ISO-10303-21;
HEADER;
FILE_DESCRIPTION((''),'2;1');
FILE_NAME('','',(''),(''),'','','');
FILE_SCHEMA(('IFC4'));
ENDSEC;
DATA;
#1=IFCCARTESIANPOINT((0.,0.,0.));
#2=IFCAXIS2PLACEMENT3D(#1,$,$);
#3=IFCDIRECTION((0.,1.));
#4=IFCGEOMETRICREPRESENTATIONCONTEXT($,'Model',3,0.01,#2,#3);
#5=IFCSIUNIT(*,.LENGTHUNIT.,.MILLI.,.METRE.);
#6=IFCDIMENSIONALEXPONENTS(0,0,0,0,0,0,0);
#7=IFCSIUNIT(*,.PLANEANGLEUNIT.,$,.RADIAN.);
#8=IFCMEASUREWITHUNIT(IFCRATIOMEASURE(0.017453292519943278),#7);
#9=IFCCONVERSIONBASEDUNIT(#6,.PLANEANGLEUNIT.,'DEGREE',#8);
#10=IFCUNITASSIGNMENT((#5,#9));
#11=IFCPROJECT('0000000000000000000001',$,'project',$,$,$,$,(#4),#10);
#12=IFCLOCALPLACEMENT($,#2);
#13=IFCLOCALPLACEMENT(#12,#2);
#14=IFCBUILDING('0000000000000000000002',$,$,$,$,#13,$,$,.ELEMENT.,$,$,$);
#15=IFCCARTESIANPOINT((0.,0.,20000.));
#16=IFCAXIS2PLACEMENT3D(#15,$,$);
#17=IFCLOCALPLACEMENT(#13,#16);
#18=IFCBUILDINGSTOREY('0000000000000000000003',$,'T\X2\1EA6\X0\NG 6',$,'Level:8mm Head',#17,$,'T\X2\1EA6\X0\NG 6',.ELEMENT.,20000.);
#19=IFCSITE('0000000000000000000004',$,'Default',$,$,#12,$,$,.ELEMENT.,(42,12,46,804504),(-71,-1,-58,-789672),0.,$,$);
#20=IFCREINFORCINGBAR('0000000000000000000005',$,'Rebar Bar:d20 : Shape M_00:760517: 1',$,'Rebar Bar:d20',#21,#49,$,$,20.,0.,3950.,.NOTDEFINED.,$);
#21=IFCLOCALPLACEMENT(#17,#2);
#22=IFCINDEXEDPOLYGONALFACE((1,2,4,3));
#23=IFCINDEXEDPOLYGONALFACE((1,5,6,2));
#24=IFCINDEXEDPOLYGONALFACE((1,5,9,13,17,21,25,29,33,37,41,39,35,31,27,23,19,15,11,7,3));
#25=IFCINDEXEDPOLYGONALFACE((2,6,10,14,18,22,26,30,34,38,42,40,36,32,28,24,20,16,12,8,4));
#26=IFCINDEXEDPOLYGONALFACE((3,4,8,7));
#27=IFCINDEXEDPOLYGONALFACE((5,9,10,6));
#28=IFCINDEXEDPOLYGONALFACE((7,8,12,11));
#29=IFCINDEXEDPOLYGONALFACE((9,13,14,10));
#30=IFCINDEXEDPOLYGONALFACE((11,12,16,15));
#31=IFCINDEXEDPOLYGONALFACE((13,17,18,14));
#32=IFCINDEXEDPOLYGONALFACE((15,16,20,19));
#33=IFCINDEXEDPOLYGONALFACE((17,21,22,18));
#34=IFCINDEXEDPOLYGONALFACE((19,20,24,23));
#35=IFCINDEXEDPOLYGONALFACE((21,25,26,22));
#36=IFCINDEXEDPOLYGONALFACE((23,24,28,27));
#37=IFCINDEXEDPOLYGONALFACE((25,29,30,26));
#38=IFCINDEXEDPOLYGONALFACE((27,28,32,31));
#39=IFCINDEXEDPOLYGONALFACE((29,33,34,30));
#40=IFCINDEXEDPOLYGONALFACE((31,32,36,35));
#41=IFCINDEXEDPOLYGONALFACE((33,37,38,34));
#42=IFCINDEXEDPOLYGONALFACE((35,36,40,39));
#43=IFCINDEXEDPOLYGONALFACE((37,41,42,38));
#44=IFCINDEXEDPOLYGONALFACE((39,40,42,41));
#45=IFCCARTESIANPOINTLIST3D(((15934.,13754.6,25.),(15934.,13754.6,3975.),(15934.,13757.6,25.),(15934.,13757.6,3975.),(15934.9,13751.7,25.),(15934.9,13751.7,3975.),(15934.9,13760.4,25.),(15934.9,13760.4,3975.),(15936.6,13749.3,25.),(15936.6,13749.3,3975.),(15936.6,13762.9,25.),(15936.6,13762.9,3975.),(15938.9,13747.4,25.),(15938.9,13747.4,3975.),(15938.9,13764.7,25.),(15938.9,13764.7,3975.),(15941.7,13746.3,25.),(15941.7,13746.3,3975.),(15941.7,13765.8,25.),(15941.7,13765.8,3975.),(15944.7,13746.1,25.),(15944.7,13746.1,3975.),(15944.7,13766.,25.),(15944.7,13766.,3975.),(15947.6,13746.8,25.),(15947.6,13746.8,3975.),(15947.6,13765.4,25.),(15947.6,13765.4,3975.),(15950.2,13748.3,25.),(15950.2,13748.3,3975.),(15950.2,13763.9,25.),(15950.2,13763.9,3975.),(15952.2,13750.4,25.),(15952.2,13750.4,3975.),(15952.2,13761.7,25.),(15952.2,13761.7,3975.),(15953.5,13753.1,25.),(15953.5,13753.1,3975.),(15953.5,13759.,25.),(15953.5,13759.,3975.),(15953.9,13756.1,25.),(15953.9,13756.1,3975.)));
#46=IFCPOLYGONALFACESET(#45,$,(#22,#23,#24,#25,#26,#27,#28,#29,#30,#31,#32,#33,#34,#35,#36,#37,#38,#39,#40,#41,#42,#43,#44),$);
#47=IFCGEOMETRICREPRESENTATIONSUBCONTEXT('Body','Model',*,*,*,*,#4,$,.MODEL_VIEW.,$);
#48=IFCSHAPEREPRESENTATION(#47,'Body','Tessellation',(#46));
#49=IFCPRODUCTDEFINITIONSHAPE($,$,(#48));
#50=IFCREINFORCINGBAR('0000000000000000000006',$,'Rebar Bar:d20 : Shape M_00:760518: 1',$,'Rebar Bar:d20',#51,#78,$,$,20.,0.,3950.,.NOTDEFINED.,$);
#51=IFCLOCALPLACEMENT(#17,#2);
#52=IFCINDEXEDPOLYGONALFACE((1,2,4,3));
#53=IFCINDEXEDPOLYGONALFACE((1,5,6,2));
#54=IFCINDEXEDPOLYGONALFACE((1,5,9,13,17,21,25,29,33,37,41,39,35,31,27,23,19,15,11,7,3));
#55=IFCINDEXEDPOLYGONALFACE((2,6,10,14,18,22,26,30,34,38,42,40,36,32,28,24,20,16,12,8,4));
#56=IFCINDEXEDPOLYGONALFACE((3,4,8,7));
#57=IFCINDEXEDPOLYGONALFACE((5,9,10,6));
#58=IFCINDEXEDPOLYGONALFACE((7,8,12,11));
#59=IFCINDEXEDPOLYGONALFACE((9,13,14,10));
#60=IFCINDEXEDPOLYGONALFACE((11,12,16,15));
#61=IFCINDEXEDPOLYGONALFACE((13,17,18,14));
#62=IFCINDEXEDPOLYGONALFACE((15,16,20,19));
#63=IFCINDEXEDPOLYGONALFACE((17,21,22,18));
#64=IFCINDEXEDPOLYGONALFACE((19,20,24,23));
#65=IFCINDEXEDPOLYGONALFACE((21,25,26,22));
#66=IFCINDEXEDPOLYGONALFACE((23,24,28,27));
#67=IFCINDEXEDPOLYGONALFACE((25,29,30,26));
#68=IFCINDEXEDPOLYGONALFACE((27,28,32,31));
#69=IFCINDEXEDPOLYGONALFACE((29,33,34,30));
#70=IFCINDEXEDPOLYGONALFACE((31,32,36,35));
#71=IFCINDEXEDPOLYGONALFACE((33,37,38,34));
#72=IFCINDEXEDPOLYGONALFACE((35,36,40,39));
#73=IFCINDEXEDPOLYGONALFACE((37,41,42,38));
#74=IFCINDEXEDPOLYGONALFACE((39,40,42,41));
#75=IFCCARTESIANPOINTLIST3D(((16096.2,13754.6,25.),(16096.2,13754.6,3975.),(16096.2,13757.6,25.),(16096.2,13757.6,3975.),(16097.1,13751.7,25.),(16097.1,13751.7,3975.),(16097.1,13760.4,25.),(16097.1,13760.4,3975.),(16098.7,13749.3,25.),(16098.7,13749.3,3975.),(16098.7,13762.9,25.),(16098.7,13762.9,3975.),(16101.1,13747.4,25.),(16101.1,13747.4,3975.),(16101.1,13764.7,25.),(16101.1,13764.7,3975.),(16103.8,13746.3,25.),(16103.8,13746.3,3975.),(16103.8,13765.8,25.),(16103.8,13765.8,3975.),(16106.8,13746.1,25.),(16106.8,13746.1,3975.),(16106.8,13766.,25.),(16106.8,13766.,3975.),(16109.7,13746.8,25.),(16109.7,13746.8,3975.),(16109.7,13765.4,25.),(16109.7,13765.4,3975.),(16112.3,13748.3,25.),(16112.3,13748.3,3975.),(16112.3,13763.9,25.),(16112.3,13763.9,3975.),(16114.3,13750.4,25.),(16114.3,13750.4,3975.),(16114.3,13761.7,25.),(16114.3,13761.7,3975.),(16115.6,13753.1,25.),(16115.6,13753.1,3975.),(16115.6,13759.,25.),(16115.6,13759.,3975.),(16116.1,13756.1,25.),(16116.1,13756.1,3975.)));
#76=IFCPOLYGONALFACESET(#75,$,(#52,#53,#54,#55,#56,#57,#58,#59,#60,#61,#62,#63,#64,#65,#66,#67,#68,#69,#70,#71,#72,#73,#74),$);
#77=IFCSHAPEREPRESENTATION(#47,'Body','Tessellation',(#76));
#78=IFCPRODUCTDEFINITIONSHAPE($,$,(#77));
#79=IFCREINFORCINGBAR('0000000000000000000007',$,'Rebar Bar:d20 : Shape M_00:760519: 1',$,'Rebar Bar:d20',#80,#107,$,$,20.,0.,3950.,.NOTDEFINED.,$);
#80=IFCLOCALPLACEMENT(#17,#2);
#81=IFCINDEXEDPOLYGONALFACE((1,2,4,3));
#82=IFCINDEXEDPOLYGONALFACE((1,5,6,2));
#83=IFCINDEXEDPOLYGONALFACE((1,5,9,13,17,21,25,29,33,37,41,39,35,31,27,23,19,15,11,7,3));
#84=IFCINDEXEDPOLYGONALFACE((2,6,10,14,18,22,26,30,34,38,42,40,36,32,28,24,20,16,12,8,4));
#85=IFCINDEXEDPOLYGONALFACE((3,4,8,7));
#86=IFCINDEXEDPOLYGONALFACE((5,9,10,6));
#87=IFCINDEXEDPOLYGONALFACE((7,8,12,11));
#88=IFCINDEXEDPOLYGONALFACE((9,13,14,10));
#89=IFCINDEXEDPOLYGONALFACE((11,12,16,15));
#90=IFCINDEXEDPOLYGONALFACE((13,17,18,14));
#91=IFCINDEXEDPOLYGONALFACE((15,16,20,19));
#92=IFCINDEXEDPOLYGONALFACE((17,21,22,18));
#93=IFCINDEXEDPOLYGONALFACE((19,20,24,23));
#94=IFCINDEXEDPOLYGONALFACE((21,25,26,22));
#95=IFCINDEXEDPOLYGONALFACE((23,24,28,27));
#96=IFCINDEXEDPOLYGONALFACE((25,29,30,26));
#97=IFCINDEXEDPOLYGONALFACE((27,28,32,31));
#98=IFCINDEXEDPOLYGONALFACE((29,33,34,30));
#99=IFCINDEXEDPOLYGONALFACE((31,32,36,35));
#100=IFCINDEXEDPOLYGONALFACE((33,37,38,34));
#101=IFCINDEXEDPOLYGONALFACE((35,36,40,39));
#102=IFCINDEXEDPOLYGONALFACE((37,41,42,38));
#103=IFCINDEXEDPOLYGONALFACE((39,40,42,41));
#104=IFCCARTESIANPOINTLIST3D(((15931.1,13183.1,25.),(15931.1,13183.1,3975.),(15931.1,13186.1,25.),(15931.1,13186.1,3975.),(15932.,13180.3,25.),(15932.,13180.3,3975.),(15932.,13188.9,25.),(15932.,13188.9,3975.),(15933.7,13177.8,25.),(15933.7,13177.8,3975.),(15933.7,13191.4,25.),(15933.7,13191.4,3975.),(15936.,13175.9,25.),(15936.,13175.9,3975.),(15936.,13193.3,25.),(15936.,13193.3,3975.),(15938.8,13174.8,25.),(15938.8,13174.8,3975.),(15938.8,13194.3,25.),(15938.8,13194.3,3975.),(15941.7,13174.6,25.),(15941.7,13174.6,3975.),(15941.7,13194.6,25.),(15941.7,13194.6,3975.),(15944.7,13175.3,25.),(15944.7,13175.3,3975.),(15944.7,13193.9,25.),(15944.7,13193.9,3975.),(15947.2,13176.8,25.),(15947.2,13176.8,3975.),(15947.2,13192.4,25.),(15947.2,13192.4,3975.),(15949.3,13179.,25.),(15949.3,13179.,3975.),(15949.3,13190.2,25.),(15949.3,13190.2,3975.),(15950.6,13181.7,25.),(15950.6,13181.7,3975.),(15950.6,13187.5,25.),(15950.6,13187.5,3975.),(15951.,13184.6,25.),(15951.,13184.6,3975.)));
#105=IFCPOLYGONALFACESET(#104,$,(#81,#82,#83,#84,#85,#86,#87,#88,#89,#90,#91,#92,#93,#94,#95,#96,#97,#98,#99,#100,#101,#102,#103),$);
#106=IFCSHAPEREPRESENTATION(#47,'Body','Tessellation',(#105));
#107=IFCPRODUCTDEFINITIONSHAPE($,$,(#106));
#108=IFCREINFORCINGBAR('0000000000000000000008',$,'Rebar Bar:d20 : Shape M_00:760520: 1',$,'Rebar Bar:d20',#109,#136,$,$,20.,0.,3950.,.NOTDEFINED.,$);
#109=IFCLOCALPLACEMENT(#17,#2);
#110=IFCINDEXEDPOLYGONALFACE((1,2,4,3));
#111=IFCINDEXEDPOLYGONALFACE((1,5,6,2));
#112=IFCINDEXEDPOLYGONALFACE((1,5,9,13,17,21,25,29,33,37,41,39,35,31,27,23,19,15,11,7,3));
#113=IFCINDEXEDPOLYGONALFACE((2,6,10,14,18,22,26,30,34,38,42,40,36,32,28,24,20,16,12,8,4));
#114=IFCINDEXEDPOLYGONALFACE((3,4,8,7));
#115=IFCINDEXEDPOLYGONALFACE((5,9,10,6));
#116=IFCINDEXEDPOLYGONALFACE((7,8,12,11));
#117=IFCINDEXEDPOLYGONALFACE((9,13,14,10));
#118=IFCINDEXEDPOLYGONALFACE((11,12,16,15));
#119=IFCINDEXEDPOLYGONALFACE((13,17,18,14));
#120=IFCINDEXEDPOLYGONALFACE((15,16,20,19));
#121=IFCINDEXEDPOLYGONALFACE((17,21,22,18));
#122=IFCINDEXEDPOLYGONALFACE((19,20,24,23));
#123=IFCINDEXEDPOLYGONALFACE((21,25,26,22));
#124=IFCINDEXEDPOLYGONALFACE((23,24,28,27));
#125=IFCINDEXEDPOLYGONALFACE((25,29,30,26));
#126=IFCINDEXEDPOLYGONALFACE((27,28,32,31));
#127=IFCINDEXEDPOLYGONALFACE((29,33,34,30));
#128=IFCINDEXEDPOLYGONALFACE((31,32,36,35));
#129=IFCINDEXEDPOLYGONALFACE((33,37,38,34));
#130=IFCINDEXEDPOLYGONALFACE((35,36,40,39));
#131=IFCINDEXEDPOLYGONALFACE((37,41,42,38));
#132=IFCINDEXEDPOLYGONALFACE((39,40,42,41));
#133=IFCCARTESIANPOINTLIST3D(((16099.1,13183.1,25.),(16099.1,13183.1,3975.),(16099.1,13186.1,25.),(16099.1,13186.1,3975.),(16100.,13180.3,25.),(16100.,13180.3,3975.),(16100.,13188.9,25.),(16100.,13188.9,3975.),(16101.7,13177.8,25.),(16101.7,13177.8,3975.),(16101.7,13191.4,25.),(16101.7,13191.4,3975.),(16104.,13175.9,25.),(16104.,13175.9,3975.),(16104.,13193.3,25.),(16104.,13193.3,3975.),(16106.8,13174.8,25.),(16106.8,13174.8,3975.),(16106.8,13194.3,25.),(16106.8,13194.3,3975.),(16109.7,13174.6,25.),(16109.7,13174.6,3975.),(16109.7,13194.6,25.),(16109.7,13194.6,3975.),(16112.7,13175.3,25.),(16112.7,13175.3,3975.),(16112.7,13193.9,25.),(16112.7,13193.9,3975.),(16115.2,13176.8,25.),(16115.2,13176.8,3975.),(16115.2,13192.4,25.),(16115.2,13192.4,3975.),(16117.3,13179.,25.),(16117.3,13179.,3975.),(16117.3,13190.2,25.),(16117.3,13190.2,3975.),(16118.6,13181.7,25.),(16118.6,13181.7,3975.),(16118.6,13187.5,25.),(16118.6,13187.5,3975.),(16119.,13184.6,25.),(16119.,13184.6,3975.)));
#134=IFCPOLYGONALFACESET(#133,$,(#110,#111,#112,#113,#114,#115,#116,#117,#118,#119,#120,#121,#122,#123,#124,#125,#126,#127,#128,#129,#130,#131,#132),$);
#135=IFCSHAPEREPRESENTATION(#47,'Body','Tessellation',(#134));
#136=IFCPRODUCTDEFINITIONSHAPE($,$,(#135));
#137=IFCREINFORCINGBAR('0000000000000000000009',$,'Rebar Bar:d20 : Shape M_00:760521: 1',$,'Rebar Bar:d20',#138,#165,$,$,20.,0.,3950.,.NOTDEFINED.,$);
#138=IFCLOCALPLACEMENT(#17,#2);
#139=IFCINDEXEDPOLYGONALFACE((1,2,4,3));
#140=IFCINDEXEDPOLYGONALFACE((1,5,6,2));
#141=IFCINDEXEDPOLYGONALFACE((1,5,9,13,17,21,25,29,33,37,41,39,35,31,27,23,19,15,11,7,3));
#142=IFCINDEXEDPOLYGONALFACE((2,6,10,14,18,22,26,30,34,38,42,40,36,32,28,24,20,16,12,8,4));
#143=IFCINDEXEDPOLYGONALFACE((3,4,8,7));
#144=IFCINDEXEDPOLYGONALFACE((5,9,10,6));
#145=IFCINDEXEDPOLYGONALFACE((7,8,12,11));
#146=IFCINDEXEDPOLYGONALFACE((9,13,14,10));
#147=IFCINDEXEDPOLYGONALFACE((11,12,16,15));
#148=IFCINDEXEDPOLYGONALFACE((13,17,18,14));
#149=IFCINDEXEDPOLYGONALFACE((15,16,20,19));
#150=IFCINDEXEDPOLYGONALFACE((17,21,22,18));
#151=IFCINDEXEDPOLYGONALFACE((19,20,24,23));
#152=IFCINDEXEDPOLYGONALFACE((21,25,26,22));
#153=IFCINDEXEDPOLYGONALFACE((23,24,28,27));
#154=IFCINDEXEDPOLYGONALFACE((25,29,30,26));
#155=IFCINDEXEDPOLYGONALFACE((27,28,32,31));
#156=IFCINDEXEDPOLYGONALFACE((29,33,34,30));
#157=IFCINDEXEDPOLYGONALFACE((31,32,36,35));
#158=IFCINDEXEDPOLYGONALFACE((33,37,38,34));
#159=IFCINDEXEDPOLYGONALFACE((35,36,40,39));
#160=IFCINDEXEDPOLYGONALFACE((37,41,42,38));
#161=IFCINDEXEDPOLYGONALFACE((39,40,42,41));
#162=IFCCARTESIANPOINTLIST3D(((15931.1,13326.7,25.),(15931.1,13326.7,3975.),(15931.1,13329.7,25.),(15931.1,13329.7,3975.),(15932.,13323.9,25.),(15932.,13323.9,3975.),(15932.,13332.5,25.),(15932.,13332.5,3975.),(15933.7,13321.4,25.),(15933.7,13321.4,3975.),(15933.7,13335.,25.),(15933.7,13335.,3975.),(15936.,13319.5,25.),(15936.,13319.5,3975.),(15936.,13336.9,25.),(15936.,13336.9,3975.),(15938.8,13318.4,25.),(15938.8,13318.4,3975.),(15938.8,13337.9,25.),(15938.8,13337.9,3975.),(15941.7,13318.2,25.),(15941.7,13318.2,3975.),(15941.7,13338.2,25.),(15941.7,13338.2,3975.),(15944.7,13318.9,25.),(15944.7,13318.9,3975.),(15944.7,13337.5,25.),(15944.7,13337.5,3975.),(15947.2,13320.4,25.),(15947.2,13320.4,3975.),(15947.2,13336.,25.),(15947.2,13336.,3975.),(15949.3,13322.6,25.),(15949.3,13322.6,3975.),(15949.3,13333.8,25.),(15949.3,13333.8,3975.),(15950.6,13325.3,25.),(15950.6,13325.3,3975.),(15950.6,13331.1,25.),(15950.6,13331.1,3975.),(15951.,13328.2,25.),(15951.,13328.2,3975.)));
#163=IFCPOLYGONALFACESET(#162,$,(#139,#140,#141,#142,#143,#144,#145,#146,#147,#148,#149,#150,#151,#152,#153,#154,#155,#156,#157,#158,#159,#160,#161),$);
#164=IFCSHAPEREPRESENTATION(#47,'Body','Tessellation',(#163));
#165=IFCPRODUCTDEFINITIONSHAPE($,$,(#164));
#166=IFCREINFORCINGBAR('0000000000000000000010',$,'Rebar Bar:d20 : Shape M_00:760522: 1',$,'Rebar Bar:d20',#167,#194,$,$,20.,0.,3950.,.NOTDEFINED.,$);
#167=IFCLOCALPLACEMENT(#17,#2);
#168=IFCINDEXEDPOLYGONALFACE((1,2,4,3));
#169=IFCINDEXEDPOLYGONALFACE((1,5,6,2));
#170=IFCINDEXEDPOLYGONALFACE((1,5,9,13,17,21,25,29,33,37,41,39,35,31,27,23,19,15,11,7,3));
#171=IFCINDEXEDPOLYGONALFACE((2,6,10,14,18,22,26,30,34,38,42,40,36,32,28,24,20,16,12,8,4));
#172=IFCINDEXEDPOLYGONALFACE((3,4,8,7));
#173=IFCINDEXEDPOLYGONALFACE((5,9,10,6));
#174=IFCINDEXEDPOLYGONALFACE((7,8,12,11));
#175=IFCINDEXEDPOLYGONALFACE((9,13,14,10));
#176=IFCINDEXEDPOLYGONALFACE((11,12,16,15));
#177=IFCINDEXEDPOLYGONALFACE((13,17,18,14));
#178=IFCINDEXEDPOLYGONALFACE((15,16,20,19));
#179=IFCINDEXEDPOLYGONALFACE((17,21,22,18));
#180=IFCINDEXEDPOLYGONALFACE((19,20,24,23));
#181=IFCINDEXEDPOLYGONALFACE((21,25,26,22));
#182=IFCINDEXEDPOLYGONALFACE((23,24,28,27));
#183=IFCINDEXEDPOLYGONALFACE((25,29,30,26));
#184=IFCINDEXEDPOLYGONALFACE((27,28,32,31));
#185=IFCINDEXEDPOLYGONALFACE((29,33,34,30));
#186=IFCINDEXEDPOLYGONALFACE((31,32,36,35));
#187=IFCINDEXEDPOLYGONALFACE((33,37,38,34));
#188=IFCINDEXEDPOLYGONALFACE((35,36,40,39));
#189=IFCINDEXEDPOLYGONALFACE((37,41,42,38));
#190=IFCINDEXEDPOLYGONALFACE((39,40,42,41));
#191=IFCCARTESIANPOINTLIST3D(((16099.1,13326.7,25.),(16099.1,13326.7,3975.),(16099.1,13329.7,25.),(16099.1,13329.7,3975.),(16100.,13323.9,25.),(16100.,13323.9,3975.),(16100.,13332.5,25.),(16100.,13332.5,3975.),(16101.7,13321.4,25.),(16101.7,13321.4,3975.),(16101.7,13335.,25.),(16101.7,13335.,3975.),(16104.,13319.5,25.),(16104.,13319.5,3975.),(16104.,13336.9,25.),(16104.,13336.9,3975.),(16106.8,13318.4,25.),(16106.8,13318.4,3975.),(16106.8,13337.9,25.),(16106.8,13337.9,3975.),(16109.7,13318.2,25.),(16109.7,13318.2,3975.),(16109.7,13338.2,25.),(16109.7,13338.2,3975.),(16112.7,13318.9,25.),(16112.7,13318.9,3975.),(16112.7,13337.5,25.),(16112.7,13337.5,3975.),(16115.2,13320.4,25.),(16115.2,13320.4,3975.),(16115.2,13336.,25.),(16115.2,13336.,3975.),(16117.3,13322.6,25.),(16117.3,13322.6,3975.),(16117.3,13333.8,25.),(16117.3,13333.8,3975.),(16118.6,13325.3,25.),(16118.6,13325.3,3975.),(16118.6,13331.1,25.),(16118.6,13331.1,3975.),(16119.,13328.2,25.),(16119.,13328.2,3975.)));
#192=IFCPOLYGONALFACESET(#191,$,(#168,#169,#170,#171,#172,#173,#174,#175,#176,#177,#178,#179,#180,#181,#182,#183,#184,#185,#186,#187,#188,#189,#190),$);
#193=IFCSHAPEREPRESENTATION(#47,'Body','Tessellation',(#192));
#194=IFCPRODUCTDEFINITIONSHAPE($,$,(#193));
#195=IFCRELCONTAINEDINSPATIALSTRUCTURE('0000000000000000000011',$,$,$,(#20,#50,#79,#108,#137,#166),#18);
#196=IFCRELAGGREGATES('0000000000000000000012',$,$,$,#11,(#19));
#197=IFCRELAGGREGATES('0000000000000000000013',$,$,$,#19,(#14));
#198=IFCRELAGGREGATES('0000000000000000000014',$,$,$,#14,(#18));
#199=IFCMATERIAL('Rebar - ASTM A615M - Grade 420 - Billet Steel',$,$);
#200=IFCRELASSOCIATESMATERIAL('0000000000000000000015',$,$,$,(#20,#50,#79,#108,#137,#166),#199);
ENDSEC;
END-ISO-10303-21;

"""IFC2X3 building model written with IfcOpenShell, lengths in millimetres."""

from ifc_helpers import new_model, entity, si_unit, converted_unit, direction, frame, origin, place, context, subcontext, project, spatial, material, element, save


model = new_model("IFC2X3")

# Units and contexts
model_context = context("Model", 3, precision=0.01, world=origin(), true_north=direction((0.0, 1.0)))
body_context = subcontext(model_context, "Body", "Model", "MODEL_VIEW")
ifc_project = project(units=[si_unit("LENGTHUNIT", "METRE", prefix="MILLI"), converted_unit("PLANEANGLEUNIT", "DEGREE", entity("IfcRatioMeasure", 0.017453292519943278), si_unit("PLANEANGLEUNIT", "RADIAN"), dimensions=[0, 0, 0, 0, 0, 0, 0])], contexts=[model_context])

# Site, building, storey
site_placement = place(None, origin())
site = spatial("IfcSite", under=ifc_project, at=site_placement, Name="Default", CompositionType="ELEMENT", RefLatitude=(42, 12, 46, 804504), RefLongitude=(-71, -1, -58, -789672), RefElevation=0.0)
building_placement = place(site_placement, origin())
building = spatial("IfcBuilding", under=site, at=building_placement, CompositionType="ELEMENT")
storey_placement = place(building_placement, frame((0.0, 0.0, 20000.0)))
storey = spatial("IfcBuildingStorey", under=building, at=storey_placement, Name="TẦNG 6", ObjectType="Level:8mm Head", LongName="TẦNG 6", CompositionType="ELEMENT", Elevation=20000.0)

# Reinforcing bars
ifc_material = material(Name="Rebar - ASTM A615M - Grade 420 - Billet Steel")
reinforcing_bar_1_placement = place(storey_placement, origin())
element("IfcReinforcingBar", 1, at=reinforcing_bar_1_placement, inside=storey, material=ifc_material, Name="Rebar Bar:d20 : Shape M_00:760517: 1", ObjectType="Rebar Bar:d20", BarLength=3950.0, BarRole="NOTDEFINED", CrossSectionArea=0.0, NominalDiameter=20.0, context=body_context, shape_type="AdvancedSweptSolid", body=[
    entity("IfcSweptDiskSolid", entity("IfcCompositeCurve", [entity("IfcCompositeCurveSegment", "CONTINUOUS", True, entity("IfcPolyline", [entity("IfcCartesianPoint", [15943.9, 13756.1, 25.0]), entity("IfcCartesianPoint", [15943.9, 13756.1, 3975.0])]))], False), 10.0, None, 0.0, 1.0),
])
reinforcing_bar_2_placement = place(storey_placement, origin())
element("IfcReinforcingBar", 2, at=reinforcing_bar_2_placement, inside=storey, material=ifc_material, Name="Rebar Bar:d20 : Shape M_00:760518: 1", ObjectType="Rebar Bar:d20", BarLength=3950.0, BarRole="NOTDEFINED", CrossSectionArea=0.0, NominalDiameter=20.0, context=body_context, shape_type="AdvancedSweptSolid", body=[
    entity("IfcSweptDiskSolid", entity("IfcCompositeCurve", [entity("IfcCompositeCurveSegment", "CONTINUOUS", True, entity("IfcPolyline", [entity("IfcCartesianPoint", [16106.1, 13756.1, 25.0]), entity("IfcCartesianPoint", [16106.1, 13756.1, 3975.0])]))], False), 10.0, None, 0.0, 1.0),
])
reinforcing_bar_3_placement = place(storey_placement, origin())
element("IfcReinforcingBar", 3, at=reinforcing_bar_3_placement, inside=storey, material=ifc_material, Name="Rebar Bar:d20 : Shape M_00:760519: 1", ObjectType="Rebar Bar:d20", BarLength=3950.0, BarRole="NOTDEFINED", CrossSectionArea=0.0, NominalDiameter=20.0, context=body_context, shape_type="AdvancedSweptSolid", body=[
    entity("IfcSweptDiskSolid", entity("IfcCompositeCurve", [entity("IfcCompositeCurveSegment", "CONTINUOUS", True, entity("IfcPolyline", [entity("IfcCartesianPoint", [15941.0, 13184.6, 25.0]), entity("IfcCartesianPoint", [15941.0, 13184.6, 3975.0])]))], False), 10.0, None, 0.0, 1.0),
])
reinforcing_bar_4_placement = place(storey_placement, origin())
element("IfcReinforcingBar", 4, at=reinforcing_bar_4_placement, inside=storey, material=ifc_material, Name="Rebar Bar:d20 : Shape M_00:760520: 1", ObjectType="Rebar Bar:d20", BarLength=3950.0, BarRole="NOTDEFINED", CrossSectionArea=0.0, NominalDiameter=20.0, context=body_context, shape_type="AdvancedSweptSolid", body=[
    entity("IfcSweptDiskSolid", entity("IfcCompositeCurve", [entity("IfcCompositeCurveSegment", "CONTINUOUS", True, entity("IfcPolyline", [entity("IfcCartesianPoint", [16109.0, 13184.6, 25.0]), entity("IfcCartesianPoint", [16109.0, 13184.6, 3975.0])]))], False), 10.0, None, 0.0, 1.0),
])
reinforcing_bar_5_placement = place(storey_placement, origin())
element("IfcReinforcingBar", 5, at=reinforcing_bar_5_placement, inside=storey, material=ifc_material, Name="Rebar Bar:d20 : Shape M_00:760521: 1", ObjectType="Rebar Bar:d20", BarLength=3950.0, BarRole="NOTDEFINED", CrossSectionArea=0.0, NominalDiameter=20.0, context=body_context, shape_type="AdvancedSweptSolid", body=[
    entity("IfcSweptDiskSolid", entity("IfcCompositeCurve", [entity("IfcCompositeCurveSegment", "CONTINUOUS", True, entity("IfcPolyline", [entity("IfcCartesianPoint", [15941.0, 13328.2, 25.0]), entity("IfcCartesianPoint", [15941.0, 13328.2, 3975.0])]))], False), 10.0, None, 0.0, 1.0),
])
reinforcing_bar_6_placement = place(storey_placement, origin())
element("IfcReinforcingBar", 6, at=reinforcing_bar_6_placement, inside=storey, material=ifc_material, Name="Rebar Bar:d20 : Shape M_00:760522: 1", ObjectType="Rebar Bar:d20", BarLength=3950.0, BarRole="NOTDEFINED", CrossSectionArea=0.0, NominalDiameter=20.0, context=body_context, shape_type="AdvancedSweptSolid", body=[
    entity("IfcSweptDiskSolid", entity("IfcCompositeCurve", [entity("IfcCompositeCurveSegment", "CONTINUOUS", True, entity("IfcPolyline", [entity("IfcCartesianPoint", [16109.0, 13328.2, 25.0]), entity("IfcCartesianPoint", [16109.0, 13328.2, 3975.0])]))], False), 10.0, None, 0.0, 1.0),
])

save(model, "model.ifc")
